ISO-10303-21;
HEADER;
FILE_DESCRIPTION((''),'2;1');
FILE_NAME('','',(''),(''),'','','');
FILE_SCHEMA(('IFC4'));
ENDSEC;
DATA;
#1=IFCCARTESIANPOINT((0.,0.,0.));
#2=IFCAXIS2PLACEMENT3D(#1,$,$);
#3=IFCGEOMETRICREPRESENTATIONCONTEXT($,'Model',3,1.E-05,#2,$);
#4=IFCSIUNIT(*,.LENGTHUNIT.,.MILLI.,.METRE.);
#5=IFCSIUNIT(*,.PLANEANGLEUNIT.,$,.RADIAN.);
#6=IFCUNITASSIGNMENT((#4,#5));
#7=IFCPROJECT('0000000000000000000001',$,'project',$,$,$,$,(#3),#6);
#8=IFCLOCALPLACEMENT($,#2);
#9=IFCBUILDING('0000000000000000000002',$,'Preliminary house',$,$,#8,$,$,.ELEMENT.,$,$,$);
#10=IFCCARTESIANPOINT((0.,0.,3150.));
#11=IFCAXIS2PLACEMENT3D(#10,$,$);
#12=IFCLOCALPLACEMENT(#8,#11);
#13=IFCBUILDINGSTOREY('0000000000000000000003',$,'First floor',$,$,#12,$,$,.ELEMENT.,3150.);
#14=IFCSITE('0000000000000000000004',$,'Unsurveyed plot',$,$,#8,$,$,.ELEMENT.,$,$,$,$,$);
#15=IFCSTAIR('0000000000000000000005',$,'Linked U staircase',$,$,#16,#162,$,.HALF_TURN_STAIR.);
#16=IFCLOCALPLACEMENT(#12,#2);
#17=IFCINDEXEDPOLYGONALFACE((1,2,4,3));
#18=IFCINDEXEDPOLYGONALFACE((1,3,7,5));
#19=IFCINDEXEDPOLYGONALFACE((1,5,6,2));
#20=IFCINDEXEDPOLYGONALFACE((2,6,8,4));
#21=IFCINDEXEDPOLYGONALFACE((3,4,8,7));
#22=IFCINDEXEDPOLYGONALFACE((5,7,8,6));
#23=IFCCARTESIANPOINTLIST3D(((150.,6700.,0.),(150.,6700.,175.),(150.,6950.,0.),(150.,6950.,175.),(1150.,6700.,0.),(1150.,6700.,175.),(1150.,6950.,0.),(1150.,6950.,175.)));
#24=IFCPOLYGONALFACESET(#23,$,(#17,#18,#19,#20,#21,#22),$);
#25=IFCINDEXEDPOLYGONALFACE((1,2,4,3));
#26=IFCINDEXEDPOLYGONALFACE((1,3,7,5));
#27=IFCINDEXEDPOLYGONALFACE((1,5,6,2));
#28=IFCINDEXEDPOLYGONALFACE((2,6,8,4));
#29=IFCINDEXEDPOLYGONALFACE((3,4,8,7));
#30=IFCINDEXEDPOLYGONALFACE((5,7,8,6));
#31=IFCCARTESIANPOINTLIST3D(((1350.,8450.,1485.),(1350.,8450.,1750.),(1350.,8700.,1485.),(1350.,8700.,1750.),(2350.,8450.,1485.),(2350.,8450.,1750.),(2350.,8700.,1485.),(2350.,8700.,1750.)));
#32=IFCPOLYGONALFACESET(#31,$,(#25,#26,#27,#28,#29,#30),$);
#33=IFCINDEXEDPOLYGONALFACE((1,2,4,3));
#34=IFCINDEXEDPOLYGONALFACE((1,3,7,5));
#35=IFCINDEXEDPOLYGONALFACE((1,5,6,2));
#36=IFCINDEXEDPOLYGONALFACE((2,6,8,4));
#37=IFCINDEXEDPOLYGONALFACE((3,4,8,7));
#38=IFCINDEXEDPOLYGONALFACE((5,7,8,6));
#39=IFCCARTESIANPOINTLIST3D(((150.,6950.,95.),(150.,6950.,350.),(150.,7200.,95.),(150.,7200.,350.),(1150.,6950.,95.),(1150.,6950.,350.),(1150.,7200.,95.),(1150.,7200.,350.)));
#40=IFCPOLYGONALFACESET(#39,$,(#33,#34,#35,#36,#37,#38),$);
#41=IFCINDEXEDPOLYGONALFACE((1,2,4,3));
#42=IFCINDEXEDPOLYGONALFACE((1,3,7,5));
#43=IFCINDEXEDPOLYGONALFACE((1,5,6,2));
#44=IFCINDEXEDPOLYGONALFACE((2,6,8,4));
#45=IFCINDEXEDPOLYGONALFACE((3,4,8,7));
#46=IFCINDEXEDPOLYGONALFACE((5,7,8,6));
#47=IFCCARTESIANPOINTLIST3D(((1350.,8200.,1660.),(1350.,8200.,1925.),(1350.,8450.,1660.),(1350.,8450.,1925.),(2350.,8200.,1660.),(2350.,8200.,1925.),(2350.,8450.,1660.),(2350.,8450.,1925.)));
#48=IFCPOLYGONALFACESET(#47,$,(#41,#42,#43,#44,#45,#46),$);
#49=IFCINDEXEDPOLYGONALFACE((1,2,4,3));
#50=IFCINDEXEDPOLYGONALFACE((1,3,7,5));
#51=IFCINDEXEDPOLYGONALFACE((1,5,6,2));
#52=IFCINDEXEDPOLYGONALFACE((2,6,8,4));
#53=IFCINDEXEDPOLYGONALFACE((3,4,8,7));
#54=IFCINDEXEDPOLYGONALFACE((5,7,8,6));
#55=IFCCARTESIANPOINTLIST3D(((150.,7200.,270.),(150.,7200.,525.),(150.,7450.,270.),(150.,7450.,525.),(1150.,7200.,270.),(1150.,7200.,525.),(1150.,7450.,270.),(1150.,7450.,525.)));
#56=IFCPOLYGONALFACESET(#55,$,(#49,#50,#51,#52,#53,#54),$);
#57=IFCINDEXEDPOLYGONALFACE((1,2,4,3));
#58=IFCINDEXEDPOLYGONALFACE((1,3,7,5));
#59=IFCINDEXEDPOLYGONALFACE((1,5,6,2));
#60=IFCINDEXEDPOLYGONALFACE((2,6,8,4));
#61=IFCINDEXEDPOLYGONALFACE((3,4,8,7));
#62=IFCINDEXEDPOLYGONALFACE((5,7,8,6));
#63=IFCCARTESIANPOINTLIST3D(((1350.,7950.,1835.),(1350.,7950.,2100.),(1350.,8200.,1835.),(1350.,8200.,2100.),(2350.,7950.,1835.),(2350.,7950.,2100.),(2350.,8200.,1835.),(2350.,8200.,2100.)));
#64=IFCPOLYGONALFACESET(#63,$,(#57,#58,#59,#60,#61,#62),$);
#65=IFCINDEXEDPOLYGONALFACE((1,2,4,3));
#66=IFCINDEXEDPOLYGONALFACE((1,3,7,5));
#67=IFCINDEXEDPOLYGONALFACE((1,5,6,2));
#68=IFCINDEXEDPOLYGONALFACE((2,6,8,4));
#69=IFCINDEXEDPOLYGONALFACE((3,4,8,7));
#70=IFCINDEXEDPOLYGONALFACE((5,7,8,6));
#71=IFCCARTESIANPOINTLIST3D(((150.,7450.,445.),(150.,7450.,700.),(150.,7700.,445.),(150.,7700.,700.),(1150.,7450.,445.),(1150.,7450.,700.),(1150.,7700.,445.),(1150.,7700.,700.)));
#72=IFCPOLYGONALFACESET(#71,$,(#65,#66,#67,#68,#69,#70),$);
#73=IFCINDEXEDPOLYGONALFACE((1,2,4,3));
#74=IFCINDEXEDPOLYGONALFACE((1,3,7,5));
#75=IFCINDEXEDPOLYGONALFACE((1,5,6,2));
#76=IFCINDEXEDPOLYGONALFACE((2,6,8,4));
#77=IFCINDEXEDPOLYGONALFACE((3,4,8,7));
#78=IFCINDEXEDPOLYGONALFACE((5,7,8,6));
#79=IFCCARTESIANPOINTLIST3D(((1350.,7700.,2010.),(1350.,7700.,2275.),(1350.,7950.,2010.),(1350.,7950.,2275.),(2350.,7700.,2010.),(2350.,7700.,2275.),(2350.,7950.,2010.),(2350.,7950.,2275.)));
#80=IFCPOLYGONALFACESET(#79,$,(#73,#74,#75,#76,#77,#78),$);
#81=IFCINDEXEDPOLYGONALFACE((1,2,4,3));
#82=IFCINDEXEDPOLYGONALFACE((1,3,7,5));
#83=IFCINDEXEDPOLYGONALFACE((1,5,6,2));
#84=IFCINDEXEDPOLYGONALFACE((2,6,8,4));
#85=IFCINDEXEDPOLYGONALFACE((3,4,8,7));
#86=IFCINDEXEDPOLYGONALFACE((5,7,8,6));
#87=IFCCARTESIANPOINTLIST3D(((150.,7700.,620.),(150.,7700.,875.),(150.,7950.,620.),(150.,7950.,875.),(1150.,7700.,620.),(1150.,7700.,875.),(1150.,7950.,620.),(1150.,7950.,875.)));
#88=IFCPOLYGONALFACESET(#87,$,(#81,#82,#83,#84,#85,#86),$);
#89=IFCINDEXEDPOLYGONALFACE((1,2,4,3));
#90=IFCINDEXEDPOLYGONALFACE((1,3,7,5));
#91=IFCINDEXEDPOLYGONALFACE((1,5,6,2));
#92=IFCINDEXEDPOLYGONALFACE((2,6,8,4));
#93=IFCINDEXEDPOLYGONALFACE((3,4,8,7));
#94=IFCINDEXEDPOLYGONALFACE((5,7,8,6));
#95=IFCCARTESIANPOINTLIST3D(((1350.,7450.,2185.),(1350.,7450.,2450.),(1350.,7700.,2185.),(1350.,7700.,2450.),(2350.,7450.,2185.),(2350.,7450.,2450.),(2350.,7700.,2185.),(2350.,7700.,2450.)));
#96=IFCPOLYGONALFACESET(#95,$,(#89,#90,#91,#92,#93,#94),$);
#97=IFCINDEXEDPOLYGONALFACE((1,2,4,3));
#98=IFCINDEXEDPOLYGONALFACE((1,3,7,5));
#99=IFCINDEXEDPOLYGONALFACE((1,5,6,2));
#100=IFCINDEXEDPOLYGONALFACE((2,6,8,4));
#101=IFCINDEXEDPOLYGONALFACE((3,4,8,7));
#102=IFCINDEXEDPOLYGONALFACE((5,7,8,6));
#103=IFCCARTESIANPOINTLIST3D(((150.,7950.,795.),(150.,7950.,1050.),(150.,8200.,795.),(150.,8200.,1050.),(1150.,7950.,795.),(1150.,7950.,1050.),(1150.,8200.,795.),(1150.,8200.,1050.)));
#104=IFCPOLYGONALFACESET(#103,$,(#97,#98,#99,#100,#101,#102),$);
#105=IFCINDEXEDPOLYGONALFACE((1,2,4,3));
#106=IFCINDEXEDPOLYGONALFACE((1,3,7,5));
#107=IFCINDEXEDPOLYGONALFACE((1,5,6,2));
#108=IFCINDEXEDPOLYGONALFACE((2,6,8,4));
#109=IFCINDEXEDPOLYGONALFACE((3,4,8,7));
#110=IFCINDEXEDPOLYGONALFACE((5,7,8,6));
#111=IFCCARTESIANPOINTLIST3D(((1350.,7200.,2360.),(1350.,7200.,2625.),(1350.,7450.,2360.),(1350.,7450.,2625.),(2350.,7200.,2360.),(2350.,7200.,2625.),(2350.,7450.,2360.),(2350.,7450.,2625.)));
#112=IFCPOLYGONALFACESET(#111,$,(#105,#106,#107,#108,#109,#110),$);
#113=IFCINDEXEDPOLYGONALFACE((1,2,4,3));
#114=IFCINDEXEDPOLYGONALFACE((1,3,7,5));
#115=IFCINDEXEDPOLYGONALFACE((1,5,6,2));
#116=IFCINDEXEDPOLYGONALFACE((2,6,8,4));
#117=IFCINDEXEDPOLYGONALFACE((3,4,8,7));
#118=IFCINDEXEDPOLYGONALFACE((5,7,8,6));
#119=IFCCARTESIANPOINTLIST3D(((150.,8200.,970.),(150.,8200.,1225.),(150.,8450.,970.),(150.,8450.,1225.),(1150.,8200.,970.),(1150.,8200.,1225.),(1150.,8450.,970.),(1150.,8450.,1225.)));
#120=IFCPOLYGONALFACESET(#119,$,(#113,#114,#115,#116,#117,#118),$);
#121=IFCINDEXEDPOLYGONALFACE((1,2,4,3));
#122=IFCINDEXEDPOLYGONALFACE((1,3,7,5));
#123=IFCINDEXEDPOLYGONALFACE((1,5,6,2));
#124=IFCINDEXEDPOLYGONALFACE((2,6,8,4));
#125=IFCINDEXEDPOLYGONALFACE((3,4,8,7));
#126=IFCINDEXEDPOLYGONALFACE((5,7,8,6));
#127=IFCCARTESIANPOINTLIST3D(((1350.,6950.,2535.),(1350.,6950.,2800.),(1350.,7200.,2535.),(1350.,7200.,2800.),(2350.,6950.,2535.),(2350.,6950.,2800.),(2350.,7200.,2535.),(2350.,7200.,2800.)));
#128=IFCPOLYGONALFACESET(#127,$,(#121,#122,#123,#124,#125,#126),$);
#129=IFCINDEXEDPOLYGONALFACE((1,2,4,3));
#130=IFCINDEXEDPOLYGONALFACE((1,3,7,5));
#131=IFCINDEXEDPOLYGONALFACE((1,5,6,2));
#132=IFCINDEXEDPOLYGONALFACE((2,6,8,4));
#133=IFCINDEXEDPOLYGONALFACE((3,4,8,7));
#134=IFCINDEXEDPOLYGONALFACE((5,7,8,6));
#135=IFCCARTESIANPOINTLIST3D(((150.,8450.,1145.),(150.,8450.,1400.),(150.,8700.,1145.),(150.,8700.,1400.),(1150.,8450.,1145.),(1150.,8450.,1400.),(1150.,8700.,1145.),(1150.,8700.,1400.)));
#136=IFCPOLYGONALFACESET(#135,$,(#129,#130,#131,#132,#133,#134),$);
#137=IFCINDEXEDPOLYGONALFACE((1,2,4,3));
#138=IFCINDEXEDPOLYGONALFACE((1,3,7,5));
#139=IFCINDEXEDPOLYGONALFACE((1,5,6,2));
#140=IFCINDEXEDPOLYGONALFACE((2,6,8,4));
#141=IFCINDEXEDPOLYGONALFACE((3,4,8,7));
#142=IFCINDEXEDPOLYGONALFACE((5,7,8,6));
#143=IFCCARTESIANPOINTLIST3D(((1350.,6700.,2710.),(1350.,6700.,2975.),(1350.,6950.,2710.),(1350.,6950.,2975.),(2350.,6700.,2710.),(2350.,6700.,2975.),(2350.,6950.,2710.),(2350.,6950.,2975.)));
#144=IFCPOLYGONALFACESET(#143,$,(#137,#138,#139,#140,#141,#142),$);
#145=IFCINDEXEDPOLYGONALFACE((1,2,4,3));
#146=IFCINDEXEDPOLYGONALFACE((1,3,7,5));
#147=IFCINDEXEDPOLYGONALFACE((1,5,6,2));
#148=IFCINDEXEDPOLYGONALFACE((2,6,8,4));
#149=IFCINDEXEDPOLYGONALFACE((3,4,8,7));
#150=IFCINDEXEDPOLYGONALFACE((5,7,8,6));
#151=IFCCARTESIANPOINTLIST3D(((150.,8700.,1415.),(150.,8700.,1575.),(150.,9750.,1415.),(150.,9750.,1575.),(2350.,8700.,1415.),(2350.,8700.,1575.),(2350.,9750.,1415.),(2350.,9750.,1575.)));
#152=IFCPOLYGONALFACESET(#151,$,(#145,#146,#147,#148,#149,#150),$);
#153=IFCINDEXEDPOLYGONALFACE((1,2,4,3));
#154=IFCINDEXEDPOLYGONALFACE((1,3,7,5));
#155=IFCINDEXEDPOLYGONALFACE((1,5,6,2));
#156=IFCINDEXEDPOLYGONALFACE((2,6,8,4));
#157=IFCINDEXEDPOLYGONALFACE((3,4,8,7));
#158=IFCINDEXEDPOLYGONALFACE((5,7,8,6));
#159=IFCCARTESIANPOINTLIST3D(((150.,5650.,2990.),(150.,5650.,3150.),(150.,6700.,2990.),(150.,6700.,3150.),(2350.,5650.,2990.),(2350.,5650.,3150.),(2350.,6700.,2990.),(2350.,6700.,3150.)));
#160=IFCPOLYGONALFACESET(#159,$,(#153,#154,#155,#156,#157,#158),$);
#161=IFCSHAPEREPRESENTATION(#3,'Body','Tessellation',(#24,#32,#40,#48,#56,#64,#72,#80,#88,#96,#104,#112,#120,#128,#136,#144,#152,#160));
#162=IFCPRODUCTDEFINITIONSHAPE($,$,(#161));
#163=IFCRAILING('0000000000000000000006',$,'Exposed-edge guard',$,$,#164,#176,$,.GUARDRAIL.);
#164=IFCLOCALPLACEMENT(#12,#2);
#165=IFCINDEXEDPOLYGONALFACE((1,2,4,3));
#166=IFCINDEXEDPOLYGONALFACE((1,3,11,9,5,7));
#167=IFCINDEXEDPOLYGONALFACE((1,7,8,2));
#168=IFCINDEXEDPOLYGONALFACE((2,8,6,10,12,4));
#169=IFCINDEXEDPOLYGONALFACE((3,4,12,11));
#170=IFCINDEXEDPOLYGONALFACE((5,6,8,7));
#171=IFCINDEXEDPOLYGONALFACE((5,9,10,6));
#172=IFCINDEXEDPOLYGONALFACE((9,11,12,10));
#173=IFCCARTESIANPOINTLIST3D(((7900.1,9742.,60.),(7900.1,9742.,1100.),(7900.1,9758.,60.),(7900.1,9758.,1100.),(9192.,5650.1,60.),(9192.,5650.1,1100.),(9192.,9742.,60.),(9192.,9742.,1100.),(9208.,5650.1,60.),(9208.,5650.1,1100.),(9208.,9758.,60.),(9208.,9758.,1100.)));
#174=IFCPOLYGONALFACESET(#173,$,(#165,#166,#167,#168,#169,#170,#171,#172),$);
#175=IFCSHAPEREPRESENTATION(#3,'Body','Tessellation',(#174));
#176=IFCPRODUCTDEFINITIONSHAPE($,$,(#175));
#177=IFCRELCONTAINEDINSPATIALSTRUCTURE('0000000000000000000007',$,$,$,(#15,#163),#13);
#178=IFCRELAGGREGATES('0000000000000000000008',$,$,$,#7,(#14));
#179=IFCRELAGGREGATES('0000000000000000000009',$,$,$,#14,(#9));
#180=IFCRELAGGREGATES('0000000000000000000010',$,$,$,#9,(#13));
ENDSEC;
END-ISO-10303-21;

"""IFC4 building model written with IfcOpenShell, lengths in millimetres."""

from ifc_helpers import new_model, si_unit, frame, origin, place, context, project, spatial, polyline, outline, extrude, element, save


model = new_model("IFC4")

# Units and contexts
model_context = context("Model", 3, precision=1e-05, world=origin())
ifc_project = project(units=[si_unit("LENGTHUNIT", "METRE", prefix="MILLI"), si_unit("PLANEANGLEUNIT", "RADIAN")], contexts=[model_context])

# Site, building, storey
placement_1 = place(None, origin())
site = spatial("IfcSite", under=ifc_project, at=placement_1, Name="Unsurveyed plot", CompositionType="ELEMENT")
building = spatial("IfcBuilding", under=site, at=placement_1, Name="Preliminary house", CompositionType="ELEMENT")
placement_2 = place(placement_1, frame((0.0, 0.0, 3150.0)))
storey = spatial("IfcBuildingStorey", under=building, at=placement_2, Name="First floor", CompositionType="ELEMENT", Elevation=3150.0)

# Stair
element("IfcStair", 1, at=placement_2, inside=storey, Name="Linked U staircase", PredefinedType="HALF_TURN_STAIR", context=model_context, shape_type="SweptSolid", body=[
    extrude(outline(polyline([(1150.0, 6700.0), (1150.0, 6950.0), (150.0, 6950.0), (150.0, 6700.0), (1150.0, 6700.0)])), origin(), (0.0, 0.0, 1.0), 175.0),
    extrude(outline(polyline([(2350.0, 8450.0), (2350.0, 8700.0), (1350.0, 8700.0), (1350.0, 8450.0), (2350.0, 8450.0)])), frame((0.0, 0.0, 1485.0)), (0.0, 0.0, 1.0), 265.0),
    extrude(outline(polyline([(1150.0, 6950.0), (1150.0, 7200.0), (150.0, 7200.0), (150.0, 6950.0), (1150.0, 6950.0)])), frame((0.0, 0.0, 95.0)), (0.0, 0.0, 1.0), 255.0),
    extrude(outline(polyline([(2350.0, 8200.0), (2350.0, 8450.0), (1350.0, 8450.0), (1350.0, 8200.0), (2350.0, 8200.0)])), frame((0.0, 0.0, 1660.0)), (0.0, 0.0, 1.0), 265.0),
    extrude(outline(polyline([(1150.0, 7200.0), (1150.0, 7450.0), (150.0, 7450.0), (150.0, 7200.0), (1150.0, 7200.0)])), frame((0.0, 0.0, 270.0)), (0.0, 0.0, 1.0), 255.0),
    extrude(outline(polyline([(2350.0, 7950.0), (2350.0, 8200.0), (1350.0, 8200.0), (1350.0, 7950.0), (2350.0, 7950.0)])), frame((0.0, 0.0, 1835.0)), (0.0, 0.0, 1.0), 265.0),
    extrude(outline(polyline([(1150.0, 7450.0), (1150.0, 7700.0), (150.0, 7700.0), (150.0, 7450.0), (1150.0, 7450.0)])), frame((0.0, 0.0, 445.0)), (0.0, 0.0, 1.0), 255.0),
    extrude(outline(polyline([(2350.0, 7700.0), (2350.0, 7950.0), (1350.0, 7950.0), (1350.0, 7700.0), (2350.0, 7700.0)])), frame((0.0, 0.0, 2010.0)), (0.0, 0.0, 1.0), 265.0),
    extrude(outline(polyline([(1150.0, 7700.0), (1150.0, 7950.0), (150.0, 7950.0), (150.0, 7700.0), (1150.0, 7700.0)])), frame((0.0, 0.0, 620.0)), (0.0, 0.0, 1.0), 255.0),
    extrude(outline(polyline([(2350.0, 7450.0), (2350.0, 7700.0), (1350.0, 7700.0), (1350.0, 7450.0), (2350.0, 7450.0)])), frame((0.0, 0.0, 2185.0)), (0.0, 0.0, 1.0), 265.0),
    extrude(outline(polyline([(1150.0, 7950.0), (1150.0, 8200.0), (150.0, 8200.0), (150.0, 7950.0), (1150.0, 7950.0)])), frame((0.0, 0.0, 795.0)), (0.0, 0.0, 1.0), 255.0),
    extrude(outline(polyline([(2350.0, 7200.0), (2350.0, 7450.0), (1350.0, 7450.0), (1350.0, 7200.0), (2350.0, 7200.0)])), frame((0.0, 0.0, 2360.0)), (0.0, 0.0, 1.0), 265.0),
    extrude(outline(polyline([(1150.0, 8200.0), (1150.0, 8450.0), (150.0, 8450.0), (150.0, 8200.0), (1150.0, 8200.0)])), frame((0.0, 0.0, 970.0)), (0.0, 0.0, 1.0), 255.0),
    extrude(outline(polyline([(2350.0, 6950.0), (2350.0, 7200.0), (1350.0, 7200.0), (1350.0, 6950.0), (2350.0, 6950.0)])), frame((0.0, 0.0, 2535.0)), (0.0, 0.0, 1.0), 265.0),
    extrude(outline(polyline([(1150.0, 8450.0), (1150.0, 8700.0), (150.0, 8700.0), (150.0, 8450.0), (1150.0, 8450.0)])), frame((0.0, 0.0, 1145.0)), (0.0, 0.0, 1.0), 255.0),
    extrude(outline(polyline([(2350.0, 6700.0), (2350.0, 6950.0), (1350.0, 6950.0), (1350.0, 6700.0), (2350.0, 6700.0)])), frame((0.0, 0.0, 2710.0)), (0.0, 0.0, 1.0), 265.0),
    extrude(outline(polyline([(2350.0, 8700.0), (2350.0, 9750.0), (150.0, 9750.0), (150.0, 8700.0), (2350.0, 8700.0)])), frame((0.0, 0.0, 1415.0)), (0.0, 0.0, 1.0), 160.0),
    extrude(outline(polyline([(2350.0, 5650.0), (2350.0, 6700.0), (150.0, 6700.0), (150.0, 5650.0), (2350.0, 5650.0)])), frame((0.0, 0.0, 2990.0)), (0.0, 0.0, 1.0), 160.0),
])

# Railing
element("IfcRailing", 2, at=placement_2, inside=storey, Name="Exposed-edge guard", PredefinedType="GUARDRAIL", context=model_context, shape_type="SweptSolid", body=[
    extrude(outline(polyline([(9192.0, 9742.0), (7900.1, 9742.0), (7900.1, 9758.0), (9208.0, 9758.0), (9208.0, 5650.1), (9192.0, 5650.1), (9192.0, 9742.0)])), frame((0.0, 0.0, 60.0)), (0.0, 0.0, 1.0), 1040.0),
])

save(model, "model.ifc")
